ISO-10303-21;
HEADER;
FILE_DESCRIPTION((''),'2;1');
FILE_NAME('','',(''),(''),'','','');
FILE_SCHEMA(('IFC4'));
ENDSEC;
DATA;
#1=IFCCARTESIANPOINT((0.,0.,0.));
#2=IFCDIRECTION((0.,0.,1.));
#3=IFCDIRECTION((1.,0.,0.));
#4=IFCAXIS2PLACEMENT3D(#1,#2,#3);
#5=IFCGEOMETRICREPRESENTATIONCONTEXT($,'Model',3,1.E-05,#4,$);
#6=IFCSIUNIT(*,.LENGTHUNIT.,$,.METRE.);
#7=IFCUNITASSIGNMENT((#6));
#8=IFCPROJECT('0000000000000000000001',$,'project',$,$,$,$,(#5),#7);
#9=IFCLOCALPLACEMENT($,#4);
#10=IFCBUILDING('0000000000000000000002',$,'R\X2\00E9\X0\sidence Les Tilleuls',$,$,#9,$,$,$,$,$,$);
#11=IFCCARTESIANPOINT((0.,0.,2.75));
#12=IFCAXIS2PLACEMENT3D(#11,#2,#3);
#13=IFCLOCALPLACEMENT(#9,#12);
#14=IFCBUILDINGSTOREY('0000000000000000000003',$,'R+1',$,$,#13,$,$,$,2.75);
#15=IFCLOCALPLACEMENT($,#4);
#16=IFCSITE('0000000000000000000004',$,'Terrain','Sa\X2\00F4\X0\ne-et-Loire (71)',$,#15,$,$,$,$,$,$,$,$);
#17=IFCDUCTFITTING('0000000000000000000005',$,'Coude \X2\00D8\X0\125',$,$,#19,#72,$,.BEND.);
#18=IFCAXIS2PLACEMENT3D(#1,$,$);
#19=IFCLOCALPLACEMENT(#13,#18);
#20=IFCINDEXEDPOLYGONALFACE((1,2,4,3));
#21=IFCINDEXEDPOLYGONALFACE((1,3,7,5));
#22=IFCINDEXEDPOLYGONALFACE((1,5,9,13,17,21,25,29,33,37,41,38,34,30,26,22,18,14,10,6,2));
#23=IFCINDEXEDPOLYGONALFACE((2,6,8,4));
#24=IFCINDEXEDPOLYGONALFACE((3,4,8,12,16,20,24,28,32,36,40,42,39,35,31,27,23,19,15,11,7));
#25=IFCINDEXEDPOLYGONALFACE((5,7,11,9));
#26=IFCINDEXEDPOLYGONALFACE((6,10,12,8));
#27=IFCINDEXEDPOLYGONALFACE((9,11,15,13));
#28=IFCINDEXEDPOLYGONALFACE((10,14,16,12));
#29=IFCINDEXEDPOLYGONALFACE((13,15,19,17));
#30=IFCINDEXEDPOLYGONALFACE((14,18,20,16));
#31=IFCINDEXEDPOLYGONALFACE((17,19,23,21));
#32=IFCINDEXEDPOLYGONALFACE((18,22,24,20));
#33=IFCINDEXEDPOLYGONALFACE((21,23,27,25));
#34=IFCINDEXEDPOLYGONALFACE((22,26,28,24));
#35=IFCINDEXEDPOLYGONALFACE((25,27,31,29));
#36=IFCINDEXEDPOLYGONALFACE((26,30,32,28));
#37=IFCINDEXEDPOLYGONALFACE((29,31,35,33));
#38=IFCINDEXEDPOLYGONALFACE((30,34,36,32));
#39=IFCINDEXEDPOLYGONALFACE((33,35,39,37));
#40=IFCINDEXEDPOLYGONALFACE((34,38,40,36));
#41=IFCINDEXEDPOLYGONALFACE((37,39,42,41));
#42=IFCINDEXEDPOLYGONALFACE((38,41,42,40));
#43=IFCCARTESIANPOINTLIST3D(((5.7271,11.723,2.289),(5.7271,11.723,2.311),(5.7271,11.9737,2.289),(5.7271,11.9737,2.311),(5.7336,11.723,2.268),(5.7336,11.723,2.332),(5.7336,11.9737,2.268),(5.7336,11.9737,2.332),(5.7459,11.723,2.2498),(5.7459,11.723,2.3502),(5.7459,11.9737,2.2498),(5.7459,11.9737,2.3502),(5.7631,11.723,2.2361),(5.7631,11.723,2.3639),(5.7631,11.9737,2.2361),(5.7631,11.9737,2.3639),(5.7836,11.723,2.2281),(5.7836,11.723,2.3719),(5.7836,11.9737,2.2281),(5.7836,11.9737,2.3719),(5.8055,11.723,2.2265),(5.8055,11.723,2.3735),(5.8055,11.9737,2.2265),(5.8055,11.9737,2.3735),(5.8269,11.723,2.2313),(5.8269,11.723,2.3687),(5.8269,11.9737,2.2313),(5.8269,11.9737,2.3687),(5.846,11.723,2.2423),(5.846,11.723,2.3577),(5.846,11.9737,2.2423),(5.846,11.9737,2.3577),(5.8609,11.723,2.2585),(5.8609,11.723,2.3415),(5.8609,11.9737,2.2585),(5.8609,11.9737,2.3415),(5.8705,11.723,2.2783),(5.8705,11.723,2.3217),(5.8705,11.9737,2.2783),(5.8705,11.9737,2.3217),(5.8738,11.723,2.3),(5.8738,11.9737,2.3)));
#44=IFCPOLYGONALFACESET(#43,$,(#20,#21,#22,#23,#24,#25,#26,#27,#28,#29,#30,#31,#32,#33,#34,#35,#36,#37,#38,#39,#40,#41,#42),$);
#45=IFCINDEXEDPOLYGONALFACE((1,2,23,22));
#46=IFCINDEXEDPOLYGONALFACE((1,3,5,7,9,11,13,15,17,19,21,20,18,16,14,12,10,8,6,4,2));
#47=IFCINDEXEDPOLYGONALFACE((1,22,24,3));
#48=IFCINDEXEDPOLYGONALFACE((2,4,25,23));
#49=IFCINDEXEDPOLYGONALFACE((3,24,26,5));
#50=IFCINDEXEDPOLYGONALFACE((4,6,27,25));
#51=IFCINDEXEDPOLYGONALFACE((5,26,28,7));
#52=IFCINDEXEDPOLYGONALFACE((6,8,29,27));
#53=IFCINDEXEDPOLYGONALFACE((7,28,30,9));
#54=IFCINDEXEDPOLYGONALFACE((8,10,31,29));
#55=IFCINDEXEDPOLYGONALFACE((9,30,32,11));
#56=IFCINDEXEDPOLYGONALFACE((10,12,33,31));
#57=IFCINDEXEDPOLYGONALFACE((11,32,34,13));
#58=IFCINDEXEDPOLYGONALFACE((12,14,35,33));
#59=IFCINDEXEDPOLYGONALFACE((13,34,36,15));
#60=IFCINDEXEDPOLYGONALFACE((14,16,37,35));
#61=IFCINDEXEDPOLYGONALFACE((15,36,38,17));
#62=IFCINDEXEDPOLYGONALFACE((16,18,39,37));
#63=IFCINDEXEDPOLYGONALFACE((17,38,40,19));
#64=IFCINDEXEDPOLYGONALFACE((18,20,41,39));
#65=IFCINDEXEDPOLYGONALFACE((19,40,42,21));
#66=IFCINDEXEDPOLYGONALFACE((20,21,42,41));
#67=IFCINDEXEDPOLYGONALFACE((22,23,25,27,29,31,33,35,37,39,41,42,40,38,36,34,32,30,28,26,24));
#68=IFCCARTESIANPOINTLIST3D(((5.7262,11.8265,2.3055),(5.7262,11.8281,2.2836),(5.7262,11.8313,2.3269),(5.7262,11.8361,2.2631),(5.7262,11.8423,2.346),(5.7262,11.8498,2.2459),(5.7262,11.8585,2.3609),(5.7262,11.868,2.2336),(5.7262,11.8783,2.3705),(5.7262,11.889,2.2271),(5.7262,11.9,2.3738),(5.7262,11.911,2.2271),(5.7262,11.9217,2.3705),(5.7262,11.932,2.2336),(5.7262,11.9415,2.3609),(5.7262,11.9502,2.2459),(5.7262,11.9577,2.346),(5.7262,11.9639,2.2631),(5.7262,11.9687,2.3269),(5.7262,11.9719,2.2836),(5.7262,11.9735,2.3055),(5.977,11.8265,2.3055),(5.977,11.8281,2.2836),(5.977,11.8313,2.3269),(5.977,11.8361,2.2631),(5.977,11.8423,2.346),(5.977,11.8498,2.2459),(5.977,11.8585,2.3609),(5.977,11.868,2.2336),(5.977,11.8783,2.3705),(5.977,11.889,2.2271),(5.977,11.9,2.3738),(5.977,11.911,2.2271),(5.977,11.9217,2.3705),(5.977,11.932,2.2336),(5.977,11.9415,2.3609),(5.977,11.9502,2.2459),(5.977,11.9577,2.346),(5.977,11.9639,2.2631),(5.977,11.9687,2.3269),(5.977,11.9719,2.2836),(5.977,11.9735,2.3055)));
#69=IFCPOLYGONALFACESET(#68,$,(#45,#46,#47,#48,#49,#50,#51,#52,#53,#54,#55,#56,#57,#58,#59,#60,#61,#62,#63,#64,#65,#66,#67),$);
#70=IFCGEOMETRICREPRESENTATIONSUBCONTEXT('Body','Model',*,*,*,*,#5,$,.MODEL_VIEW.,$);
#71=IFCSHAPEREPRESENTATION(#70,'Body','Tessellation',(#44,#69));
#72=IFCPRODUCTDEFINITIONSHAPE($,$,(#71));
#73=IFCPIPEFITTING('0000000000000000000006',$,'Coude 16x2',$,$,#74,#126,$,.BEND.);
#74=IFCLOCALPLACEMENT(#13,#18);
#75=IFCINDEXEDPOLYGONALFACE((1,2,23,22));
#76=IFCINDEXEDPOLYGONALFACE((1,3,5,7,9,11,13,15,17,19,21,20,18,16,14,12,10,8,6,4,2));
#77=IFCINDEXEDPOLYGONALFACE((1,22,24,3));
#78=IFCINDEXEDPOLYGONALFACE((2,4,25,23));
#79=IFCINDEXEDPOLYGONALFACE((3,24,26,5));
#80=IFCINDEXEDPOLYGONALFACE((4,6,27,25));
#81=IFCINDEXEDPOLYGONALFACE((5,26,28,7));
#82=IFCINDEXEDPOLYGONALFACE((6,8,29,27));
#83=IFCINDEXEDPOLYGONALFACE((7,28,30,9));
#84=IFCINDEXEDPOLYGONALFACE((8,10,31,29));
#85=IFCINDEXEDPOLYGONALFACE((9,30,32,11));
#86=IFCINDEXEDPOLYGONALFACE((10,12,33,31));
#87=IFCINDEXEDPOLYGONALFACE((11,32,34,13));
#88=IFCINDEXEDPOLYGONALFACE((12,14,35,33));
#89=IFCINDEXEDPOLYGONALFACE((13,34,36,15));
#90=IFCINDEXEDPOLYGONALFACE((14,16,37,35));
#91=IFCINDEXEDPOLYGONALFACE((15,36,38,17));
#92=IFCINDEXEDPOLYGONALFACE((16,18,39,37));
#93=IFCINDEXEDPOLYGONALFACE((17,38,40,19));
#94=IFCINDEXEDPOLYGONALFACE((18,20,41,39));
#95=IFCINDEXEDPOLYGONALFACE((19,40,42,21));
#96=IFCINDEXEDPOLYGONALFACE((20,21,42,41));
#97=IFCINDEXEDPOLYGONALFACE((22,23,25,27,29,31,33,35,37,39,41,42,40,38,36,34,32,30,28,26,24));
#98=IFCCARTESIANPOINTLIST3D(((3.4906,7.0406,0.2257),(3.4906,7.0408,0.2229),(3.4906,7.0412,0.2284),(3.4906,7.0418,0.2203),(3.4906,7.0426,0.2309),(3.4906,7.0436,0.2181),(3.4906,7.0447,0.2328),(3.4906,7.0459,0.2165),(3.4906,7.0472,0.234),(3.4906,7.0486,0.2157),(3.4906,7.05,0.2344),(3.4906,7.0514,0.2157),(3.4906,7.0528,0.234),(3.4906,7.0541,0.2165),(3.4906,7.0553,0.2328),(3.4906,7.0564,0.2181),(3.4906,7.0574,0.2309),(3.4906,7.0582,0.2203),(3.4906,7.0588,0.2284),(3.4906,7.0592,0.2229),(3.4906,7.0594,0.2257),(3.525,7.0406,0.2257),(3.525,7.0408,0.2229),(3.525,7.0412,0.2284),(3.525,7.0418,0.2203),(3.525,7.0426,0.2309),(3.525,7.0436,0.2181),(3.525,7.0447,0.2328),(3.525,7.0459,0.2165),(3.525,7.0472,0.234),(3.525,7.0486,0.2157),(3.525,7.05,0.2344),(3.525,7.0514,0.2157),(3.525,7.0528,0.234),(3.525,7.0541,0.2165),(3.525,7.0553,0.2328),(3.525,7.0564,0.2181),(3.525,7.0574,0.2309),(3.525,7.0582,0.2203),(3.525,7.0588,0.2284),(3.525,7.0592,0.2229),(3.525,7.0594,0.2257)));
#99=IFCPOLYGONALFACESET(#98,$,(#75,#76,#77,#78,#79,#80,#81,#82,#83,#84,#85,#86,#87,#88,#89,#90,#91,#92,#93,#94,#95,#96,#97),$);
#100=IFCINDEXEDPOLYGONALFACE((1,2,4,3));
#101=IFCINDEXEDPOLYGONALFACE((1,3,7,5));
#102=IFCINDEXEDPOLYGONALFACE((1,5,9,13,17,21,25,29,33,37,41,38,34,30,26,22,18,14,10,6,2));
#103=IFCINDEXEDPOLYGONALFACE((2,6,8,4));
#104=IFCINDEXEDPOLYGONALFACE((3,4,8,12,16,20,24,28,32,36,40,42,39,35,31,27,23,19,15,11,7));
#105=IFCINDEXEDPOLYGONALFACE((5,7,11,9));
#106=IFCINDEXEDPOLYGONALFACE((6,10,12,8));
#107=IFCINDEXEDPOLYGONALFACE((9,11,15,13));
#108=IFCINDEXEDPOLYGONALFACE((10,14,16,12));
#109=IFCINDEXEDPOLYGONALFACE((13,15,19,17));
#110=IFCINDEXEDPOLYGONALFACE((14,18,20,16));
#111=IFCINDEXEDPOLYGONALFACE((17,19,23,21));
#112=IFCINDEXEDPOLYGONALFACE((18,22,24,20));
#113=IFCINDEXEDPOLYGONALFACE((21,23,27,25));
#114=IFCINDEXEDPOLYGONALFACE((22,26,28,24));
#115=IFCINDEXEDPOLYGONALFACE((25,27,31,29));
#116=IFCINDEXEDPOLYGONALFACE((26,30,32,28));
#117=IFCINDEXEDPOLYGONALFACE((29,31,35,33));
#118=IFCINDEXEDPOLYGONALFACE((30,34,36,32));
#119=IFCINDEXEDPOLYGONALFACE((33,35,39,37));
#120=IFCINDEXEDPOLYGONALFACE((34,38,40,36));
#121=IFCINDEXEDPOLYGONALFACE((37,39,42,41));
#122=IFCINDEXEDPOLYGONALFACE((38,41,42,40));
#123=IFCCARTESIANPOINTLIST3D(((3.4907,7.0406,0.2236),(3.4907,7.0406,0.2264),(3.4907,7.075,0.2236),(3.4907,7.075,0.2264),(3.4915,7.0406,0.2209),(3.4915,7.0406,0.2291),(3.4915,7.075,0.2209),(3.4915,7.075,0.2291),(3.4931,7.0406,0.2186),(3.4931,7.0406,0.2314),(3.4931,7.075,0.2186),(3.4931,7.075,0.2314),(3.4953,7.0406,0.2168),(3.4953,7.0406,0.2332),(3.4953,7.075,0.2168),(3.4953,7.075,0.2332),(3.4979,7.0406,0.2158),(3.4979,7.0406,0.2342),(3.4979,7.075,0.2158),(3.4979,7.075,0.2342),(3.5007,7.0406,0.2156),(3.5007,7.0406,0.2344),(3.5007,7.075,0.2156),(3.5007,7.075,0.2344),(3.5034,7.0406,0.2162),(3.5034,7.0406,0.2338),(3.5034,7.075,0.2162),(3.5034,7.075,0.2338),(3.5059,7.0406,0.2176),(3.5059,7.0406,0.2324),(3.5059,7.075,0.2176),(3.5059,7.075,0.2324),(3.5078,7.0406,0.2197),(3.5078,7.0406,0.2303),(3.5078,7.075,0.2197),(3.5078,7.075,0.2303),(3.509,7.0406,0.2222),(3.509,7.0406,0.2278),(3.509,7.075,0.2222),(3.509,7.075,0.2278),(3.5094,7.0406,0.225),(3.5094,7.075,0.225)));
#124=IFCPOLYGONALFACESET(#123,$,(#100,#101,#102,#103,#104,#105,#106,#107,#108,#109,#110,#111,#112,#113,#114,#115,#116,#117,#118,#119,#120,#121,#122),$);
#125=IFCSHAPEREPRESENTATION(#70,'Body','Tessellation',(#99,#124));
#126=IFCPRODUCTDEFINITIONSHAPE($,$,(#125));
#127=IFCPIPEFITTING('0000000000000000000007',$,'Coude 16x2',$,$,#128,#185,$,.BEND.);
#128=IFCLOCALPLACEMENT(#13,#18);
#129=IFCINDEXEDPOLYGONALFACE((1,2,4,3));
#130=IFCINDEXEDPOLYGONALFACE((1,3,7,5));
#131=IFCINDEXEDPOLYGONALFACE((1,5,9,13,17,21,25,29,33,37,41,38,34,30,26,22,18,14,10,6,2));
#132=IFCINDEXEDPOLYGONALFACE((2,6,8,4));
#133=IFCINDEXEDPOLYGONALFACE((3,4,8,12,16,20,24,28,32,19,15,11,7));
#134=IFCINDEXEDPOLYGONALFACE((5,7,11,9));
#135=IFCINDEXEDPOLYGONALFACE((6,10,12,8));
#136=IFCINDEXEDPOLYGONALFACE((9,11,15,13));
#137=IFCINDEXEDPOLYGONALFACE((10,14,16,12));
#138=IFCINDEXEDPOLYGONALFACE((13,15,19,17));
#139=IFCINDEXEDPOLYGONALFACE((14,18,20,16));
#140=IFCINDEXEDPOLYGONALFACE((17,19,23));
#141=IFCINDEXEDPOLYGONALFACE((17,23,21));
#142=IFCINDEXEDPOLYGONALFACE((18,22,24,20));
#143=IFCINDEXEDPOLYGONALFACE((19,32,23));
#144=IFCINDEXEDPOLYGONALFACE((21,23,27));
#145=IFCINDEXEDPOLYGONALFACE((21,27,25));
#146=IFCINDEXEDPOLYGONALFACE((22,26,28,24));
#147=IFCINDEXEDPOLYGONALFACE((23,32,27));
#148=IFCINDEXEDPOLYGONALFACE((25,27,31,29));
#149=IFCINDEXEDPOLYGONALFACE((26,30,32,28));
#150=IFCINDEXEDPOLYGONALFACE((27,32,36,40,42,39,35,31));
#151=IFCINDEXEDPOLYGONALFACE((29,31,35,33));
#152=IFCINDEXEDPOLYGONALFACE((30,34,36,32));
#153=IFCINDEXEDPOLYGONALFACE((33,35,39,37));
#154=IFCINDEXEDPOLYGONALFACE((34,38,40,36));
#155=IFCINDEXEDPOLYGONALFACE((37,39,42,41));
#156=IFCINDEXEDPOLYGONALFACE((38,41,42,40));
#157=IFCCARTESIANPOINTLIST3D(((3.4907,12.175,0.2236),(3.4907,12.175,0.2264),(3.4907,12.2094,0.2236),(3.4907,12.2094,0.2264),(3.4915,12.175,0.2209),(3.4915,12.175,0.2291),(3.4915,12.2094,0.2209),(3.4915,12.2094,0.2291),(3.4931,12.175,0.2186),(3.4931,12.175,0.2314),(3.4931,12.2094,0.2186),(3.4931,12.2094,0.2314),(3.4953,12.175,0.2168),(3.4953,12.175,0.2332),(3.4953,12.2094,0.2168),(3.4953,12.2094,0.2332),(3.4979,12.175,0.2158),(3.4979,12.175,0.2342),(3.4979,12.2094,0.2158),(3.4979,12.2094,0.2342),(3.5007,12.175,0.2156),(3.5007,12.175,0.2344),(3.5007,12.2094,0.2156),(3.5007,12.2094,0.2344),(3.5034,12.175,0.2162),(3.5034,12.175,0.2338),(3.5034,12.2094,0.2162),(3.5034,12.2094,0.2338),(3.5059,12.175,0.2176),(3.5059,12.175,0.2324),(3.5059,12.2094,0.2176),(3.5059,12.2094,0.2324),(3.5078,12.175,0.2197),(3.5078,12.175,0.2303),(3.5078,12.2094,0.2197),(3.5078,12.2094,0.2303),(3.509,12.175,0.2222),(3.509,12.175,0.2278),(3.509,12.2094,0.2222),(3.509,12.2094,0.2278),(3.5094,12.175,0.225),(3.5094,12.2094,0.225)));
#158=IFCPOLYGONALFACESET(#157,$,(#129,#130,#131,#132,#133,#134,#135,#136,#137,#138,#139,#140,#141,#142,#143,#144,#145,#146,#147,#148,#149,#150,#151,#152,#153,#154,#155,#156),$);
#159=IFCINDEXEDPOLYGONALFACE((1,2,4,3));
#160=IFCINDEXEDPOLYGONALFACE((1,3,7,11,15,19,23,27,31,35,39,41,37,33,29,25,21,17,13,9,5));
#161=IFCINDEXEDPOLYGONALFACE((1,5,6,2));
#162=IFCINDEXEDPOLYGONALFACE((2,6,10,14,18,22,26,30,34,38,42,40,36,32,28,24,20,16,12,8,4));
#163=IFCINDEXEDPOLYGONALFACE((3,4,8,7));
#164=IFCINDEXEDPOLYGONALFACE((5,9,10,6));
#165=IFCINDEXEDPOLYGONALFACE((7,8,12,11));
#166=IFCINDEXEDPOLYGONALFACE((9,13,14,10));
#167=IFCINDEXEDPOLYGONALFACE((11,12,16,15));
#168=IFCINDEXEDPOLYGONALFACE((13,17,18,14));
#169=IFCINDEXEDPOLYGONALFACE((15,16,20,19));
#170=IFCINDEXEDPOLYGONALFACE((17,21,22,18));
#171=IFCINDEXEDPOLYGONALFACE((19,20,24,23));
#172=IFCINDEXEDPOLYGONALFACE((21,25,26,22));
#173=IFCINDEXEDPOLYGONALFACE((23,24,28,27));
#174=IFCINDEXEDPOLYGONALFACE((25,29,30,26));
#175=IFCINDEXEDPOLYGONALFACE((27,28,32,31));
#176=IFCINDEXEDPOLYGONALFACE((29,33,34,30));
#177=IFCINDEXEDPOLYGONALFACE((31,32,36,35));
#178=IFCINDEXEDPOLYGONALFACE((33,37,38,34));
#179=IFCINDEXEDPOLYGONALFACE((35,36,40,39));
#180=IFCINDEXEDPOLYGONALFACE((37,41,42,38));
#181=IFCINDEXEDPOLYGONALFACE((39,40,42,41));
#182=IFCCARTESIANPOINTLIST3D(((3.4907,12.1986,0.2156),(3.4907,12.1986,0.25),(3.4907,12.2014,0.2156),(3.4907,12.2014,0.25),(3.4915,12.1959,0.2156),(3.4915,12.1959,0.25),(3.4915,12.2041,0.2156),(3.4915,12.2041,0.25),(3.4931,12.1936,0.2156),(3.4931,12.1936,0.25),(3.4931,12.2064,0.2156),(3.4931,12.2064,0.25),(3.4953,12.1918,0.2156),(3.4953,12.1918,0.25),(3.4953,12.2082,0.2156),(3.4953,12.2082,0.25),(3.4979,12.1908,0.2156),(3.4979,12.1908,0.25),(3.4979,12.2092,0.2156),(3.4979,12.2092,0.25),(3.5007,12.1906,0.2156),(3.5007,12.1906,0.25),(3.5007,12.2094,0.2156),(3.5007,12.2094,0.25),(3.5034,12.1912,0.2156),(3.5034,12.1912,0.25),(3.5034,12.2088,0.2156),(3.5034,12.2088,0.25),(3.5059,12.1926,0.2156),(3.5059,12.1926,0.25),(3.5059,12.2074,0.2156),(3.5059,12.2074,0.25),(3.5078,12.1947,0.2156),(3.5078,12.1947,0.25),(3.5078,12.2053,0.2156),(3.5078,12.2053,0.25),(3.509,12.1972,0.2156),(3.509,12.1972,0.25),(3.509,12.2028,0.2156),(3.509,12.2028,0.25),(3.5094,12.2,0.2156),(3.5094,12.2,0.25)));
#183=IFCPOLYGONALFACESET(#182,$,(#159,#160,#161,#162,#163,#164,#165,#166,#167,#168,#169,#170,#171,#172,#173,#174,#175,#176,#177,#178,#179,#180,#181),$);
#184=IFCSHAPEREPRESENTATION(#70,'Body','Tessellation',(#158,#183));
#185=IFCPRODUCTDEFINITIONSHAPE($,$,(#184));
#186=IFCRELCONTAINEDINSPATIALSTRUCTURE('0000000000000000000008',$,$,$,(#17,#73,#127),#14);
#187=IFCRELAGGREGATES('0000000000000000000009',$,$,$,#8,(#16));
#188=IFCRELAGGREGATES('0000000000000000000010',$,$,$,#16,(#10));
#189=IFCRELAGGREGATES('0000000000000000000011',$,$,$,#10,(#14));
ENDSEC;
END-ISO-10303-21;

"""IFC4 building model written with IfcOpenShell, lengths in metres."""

from ifc_helpers import new_model, si_unit, frame, origin_with_axes, place, context, subcontext, project, spatial, circle, extrude, element, save


model = new_model("IFC4")

# Units and contexts
model_context = context("Model", 3, precision=1e-05, world=origin_with_axes())
body_context = subcontext(model_context, "Body", "Model", "MODEL_VIEW")
ifc_project = project(units=[si_unit("LENGTHUNIT", "METRE")], contexts=[model_context])

# Site, building, storey
site_placement = place(None, origin_with_axes())
site = spatial("IfcSite", under=ifc_project, at=site_placement, Name="Terrain", Description="Saône-et-Loire (71)")
building_placement = place(None, origin_with_axes())
building = spatial("IfcBuilding", under=site, at=building_placement, Name="Résidence Les Tilleuls")
storey_placement = place(building_placement, frame((0.0, 0.0, 2.75), z_axis=(0.0, 0.0, 1.0), x_axis=(1.0, 0.0, 0.0)))
storey = spatial("IfcBuildingStorey", under=building, at=storey_placement, Name="R+1", Elevation=2.75)

# Duct fitting
duct_fitting_1_placement = place(storey_placement, frame((5.8, 11.9, 2.3), z_axis=(0.0, 0.0, 1.0), x_axis=(1.0, 0.0, 0.0)))
element("IfcDuctFitting", 1, at=duct_fitting_1_placement, inside=storey, Name="Coude Ø125", PredefinedType="BEND", context=body_context, shape_type="SweptSolid", body=[
    extrude(circle(Radius=0.0737), frame((0.0, 0.0737, 0.0), z_axis=(0.0, -1.0, 0.0), x_axis=(1.0, 0.0, 0.0)), (0.0, 0.0, 1.0), 0.2507),
    extrude(circle(Radius=0.0737), frame((-0.0737, 0.0, 0.0), z_axis=(1.0, 0.0, 0.0), x_axis=(0.0, 0.0, 1.0)), (0.0, 0.0, 1.0), 0.2507),
])

# Pipe fittings
pipe_fitting_1_placement = place(storey_placement, frame((3.5, 7.05, 0.225), z_axis=(0.0, 0.0, 1.0), x_axis=(1.0, 0.0, 0.0)))
element("IfcPipeFitting", 2, at=pipe_fitting_1_placement, inside=storey, Name="Coude 16x2", PredefinedType="BEND", context=body_context, shape_type="SweptSolid", body=[
    extrude(circle(Radius=0.0094), frame((-0.0094, 0.0, 0.0), z_axis=(1.0, 0.0, 0.0), x_axis=(0.0, 0.0, 1.0)), (0.0, 0.0, 1.0), 0.0344),
    extrude(circle(Radius=0.0094), frame((0.0, -0.0094, 0.0), z_axis=(0.0, 1.0, 0.0), x_axis=(1.0, 0.0, 0.0)), (0.0, 0.0, 1.0), 0.0344),
])
for number, where, z_axis, x_axis, name in (
    (3, (3.5, 12.2, 0.225), (0.0, 0.0, 1.0), (1.0, 0.0, 0.0), "Coude 16x2"),
):
    element("IfcPipeFitting", number, at=place(storey_placement, frame(where, z_axis=z_axis, x_axis=x_axis)), inside=storey, Name=name, PredefinedType="BEND", context=body_context, shape_type="SweptSolid", body=[
        extrude(circle(Radius=0.0094), frame((0.0, 0.0094, 0.0), z_axis=(0.0, -1.0, 0.0), x_axis=(1.0, 0.0, 0.0)), (0.0, 0.0, 1.0), 0.0344),
        extrude(circle(Radius=0.0094), frame((0.0, 0.0, -0.0094), z_axis=(0.0, 0.0, 1.0), x_axis=(1.0, 0.0, 0.0)), (0.0, 0.0, 1.0), 0.0344),
    ])

save(model, "model.ifc")
